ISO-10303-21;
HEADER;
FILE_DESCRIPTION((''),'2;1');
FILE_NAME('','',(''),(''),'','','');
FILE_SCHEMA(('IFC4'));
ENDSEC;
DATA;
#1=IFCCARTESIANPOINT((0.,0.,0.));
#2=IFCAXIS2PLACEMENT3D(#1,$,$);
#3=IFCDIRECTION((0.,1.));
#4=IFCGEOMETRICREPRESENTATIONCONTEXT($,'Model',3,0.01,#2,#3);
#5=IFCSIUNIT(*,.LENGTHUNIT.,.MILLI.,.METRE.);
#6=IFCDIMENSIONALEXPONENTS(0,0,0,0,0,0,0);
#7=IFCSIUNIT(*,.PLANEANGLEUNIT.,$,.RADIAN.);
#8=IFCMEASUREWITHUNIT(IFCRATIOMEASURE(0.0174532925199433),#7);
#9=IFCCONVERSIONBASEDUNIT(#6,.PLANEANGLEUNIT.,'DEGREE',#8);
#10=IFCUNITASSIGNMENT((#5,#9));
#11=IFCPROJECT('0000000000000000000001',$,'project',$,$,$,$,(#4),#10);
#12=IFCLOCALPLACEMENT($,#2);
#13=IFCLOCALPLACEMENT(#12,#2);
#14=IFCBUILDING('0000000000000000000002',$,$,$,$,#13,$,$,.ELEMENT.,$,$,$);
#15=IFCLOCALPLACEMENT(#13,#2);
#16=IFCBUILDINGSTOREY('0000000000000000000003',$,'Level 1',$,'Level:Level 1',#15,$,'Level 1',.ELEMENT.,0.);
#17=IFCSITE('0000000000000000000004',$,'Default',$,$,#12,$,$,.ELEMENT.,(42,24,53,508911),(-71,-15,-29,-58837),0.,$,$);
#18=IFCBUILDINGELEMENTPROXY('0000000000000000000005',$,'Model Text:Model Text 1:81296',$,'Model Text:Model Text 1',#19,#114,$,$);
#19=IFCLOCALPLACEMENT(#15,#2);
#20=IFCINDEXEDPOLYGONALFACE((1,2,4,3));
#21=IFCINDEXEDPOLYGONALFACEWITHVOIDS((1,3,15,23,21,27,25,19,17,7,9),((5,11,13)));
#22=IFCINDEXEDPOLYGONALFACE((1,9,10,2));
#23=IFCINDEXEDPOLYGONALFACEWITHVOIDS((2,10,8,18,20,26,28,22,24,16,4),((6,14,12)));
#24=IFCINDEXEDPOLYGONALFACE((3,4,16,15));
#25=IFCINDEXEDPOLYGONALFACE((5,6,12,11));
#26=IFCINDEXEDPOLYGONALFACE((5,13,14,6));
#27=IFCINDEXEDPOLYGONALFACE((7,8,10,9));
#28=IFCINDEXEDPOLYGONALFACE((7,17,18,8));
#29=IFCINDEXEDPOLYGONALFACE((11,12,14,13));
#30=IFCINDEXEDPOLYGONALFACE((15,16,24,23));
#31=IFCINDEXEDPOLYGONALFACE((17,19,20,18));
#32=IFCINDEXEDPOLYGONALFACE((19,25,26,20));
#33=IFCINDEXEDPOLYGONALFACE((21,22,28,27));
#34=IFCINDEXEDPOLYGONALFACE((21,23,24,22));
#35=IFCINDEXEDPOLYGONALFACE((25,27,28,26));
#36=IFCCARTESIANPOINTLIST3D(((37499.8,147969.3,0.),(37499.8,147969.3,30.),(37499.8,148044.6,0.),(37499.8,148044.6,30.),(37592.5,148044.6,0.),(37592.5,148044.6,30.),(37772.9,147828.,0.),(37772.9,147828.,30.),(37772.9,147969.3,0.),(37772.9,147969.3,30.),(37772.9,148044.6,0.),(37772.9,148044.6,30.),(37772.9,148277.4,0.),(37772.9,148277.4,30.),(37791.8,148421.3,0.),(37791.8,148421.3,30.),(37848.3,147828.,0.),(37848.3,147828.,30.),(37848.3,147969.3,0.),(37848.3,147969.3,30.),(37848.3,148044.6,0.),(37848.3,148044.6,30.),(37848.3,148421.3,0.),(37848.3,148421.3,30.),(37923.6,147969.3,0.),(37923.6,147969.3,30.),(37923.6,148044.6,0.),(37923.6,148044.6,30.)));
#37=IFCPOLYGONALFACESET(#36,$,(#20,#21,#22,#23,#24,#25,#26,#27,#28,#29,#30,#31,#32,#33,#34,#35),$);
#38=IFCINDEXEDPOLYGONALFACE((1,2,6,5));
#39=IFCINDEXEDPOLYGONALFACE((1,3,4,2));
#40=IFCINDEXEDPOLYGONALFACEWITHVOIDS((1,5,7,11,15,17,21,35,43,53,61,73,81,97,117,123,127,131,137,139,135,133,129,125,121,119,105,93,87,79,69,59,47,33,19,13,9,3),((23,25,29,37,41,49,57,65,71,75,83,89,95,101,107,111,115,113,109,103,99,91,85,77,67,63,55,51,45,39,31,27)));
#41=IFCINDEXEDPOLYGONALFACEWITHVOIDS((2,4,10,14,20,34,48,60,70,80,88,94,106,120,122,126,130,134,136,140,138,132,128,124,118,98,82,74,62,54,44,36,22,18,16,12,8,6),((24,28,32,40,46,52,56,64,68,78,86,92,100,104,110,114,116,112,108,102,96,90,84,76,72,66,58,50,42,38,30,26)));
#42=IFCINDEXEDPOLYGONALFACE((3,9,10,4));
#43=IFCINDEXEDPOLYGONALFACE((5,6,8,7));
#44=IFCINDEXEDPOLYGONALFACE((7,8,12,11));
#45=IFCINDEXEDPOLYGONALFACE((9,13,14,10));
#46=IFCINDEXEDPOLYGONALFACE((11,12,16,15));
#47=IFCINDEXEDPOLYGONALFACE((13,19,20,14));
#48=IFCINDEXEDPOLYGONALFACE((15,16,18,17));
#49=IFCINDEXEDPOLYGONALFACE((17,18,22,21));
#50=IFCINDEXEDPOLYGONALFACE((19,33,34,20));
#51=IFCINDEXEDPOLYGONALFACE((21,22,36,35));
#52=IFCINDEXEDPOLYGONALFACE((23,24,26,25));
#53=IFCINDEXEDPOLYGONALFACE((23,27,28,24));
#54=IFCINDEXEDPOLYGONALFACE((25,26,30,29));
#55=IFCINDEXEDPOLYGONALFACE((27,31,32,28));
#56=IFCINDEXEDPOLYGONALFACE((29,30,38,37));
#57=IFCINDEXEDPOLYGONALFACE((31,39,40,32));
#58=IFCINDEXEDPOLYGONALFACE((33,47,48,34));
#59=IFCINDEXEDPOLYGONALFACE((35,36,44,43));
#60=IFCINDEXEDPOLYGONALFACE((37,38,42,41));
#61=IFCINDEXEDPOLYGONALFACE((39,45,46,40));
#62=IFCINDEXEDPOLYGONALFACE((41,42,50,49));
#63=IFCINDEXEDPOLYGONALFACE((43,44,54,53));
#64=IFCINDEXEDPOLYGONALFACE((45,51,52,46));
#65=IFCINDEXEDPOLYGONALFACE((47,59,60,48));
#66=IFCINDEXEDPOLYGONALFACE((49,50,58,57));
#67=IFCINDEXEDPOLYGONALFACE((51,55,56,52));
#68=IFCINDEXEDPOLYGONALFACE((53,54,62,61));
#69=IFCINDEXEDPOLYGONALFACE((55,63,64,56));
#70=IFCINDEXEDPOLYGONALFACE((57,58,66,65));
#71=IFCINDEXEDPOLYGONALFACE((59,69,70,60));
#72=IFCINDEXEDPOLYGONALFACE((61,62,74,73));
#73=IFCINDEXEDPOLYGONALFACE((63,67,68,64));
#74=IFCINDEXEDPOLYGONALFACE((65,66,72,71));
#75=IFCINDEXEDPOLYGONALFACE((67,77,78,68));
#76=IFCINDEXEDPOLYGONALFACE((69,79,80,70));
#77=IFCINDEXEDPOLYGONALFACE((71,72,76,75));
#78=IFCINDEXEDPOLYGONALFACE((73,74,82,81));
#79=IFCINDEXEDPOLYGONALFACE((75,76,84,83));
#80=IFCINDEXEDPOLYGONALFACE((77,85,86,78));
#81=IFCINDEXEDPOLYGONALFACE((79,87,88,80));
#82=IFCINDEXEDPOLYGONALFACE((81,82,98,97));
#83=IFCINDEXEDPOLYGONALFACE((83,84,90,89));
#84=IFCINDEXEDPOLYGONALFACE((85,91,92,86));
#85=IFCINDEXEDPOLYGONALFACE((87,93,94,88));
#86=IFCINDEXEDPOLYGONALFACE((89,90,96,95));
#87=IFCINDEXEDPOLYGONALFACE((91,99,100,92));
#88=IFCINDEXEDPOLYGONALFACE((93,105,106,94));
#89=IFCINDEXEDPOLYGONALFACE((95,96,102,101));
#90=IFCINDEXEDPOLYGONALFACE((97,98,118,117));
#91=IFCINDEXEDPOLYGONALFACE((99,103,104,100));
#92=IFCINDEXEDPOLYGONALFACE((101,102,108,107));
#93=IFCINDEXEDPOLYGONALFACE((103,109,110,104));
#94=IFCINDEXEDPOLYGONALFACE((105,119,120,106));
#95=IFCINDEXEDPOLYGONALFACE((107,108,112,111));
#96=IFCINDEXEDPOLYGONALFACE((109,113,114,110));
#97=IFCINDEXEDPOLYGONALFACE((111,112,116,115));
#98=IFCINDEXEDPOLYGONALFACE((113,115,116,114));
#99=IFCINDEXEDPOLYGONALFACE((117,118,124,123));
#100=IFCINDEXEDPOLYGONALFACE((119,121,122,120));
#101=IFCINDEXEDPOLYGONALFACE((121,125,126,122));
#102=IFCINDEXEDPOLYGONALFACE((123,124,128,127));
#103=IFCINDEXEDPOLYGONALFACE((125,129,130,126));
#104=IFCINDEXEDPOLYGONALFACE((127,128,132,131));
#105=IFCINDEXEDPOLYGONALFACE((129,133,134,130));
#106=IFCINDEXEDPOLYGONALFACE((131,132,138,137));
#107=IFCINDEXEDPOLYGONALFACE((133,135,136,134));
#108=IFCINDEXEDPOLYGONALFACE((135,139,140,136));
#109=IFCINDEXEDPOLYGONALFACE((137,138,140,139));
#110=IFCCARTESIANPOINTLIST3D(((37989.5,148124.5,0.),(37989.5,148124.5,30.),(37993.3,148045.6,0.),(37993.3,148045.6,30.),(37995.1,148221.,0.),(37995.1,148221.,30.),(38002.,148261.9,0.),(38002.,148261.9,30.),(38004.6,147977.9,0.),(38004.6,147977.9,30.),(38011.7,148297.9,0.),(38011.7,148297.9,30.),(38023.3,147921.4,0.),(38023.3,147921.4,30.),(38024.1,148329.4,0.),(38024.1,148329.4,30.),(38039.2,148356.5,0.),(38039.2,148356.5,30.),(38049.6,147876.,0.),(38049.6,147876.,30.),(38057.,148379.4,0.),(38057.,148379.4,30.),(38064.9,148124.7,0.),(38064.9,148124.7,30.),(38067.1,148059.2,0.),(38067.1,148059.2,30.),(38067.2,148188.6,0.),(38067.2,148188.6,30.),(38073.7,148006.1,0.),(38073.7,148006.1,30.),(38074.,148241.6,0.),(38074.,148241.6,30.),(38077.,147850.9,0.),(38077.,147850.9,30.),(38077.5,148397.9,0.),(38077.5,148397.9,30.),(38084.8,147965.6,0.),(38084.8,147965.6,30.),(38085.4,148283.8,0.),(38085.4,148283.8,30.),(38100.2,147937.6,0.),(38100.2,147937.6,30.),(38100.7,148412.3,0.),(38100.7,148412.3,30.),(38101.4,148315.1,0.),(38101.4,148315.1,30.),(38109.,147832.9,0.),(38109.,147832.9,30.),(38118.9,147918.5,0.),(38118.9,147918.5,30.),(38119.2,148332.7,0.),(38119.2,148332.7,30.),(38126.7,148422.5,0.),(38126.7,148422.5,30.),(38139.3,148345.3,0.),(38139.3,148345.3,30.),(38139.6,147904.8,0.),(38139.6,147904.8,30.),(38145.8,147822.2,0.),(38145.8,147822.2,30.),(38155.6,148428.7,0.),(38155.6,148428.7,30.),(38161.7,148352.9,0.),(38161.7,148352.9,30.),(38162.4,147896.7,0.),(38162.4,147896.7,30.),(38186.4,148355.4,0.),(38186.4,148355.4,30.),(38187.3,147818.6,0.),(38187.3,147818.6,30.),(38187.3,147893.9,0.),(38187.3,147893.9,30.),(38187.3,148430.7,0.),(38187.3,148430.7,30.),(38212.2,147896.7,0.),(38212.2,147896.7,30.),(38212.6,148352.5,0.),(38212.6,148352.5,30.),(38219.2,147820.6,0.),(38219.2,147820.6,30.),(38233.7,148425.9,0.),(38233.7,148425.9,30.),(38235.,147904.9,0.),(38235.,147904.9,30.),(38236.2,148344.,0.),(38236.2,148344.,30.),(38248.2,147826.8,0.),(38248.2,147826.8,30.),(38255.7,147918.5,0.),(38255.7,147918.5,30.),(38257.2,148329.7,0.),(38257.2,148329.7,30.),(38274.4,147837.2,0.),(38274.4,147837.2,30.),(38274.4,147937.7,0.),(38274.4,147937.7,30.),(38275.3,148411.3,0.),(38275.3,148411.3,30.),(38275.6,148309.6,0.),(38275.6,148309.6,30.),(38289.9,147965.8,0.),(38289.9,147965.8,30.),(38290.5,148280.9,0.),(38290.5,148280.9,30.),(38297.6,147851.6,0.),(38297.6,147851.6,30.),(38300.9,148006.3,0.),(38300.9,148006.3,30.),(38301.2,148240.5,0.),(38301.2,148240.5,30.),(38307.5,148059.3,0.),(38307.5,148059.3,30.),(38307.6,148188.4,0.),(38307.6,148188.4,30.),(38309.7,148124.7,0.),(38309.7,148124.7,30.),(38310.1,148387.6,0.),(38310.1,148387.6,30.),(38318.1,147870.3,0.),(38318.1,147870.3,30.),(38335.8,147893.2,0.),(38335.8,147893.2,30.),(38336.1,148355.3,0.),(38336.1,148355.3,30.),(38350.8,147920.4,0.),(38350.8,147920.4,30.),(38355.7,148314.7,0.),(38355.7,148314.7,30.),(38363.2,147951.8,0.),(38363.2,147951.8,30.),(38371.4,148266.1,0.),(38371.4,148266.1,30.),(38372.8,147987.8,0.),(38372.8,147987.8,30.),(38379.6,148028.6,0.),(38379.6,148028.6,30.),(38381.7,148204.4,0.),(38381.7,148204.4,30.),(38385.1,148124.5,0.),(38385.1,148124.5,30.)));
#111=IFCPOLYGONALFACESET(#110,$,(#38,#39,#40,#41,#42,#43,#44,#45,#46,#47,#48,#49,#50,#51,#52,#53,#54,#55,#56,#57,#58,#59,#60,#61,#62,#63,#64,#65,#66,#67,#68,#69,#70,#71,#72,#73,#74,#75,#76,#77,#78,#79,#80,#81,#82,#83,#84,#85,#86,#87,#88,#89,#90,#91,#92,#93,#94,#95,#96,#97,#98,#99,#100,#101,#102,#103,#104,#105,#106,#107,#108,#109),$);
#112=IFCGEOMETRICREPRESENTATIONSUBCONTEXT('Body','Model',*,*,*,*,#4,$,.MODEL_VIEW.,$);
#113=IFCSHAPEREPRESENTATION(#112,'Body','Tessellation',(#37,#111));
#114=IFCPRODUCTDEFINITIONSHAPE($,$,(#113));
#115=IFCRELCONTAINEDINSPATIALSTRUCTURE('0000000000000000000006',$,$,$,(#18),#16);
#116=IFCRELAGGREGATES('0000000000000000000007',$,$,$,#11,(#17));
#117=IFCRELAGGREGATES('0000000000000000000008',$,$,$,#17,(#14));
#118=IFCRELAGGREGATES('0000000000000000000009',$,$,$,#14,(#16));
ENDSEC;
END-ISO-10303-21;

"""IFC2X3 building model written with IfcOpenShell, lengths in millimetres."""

from ifc_helpers import new_model, entity, si_unit, converted_unit, direction, frame, origin, place, context, subcontext, project, spatial, polyline, outline, extrude, element, save


model = new_model("IFC2X3")

# Units and contexts
model_context = context("Model", 3, precision=0.01, world=origin(), true_north=direction((0.0, 1.0)))
body_context = subcontext(model_context, "Body", "Model", "MODEL_VIEW")
ifc_project = project(units=[si_unit("LENGTHUNIT", "METRE", prefix="MILLI"), converted_unit("PLANEANGLEUNIT", "DEGREE", entity("IfcRatioMeasure", 0.0174532925199433), si_unit("PLANEANGLEUNIT", "RADIAN"), dimensions=[0, 0, 0, 0, 0, 0, 0])], contexts=[model_context])

# Site, building, storey
site_placement = place(None, origin())
site = spatial("IfcSite", under=ifc_project, at=site_placement, Name="Default", CompositionType="ELEMENT", RefLatitude=(42, 24, 53, 508911), RefLongitude=(-71, -15, -29, -58837), RefElevation=0.0)
building_placement = place(site_placement, origin())
building = spatial("IfcBuilding", under=site, at=building_placement, CompositionType="ELEMENT")
storey_placement = place(building_placement, origin())
storey = spatial("IfcBuildingStorey", under=building, at=storey_placement, Name="Level 1", ObjectType="Level:Level 1", LongName="Level 1", CompositionType="ELEMENT", Elevation=0.0)

# Building element proxy
proxy_1_placement = place(storey_placement, origin())
element("IfcBuildingElementProxy", 1, at=proxy_1_placement, inside=storey, Name="Model Text:Model Text 1:81296", ObjectType="Model Text:Model Text 1", context=body_context, shape_type="SweptSolid", body=[
    extrude(outline(polyline([(-6.8, -218.3), (68.5, -218.3), (68.5, -77.1), (143.8, -77.1), (143.8, -1.7), (68.5, -1.7), (68.5, 375.0), (12.0, 375.0), (-280.0, -1.7), (-280.0, -77.1), (-6.8, -77.1), (-6.8, -218.3)]), holes=[polyline([(-6.8, -1.7), (-187.3, -1.7), (-6.8, 231.1), (-6.8, -1.7)])]), frame((37779.8, 148046.3, 0.0)), (0.0, 0.0, 1.0), 30.0),
    extrude(outline(polyline([(-10.6, -198.7), (68.3, -198.7), (136.5, -190.7), (193.9, -174.7), (240.5, -150.6), (266.9, -124.4), (286.3, -93.2), (298.8, -57.0), (304.3, -15.7), (303.8, 16.2), (299.0, 45.5), (289.9, 72.1), (276.6, 96.0), (258.9, 117.3), (236.9, 136.2), (210.4, 152.5), (179.6, 166.3), (144.1, 177.6), (103.7, 186.3), (8.2, 196.4), (-71.8, 196.7), (-134.0, 189.4), (-183.3, 176.1), (-224.7, 158.4), (-258.2, 133.9), (-283.5, 100.3), (-300.1, 59.5), (-307.1, 13.4), (-306.6, -18.4), (-301.8, -47.5), (-292.8, -74.0), (-279.6, -97.9), (-262.0, -119.2), (-240.0, -138.1), (-213.6, -154.5), (-182.8, -168.4), (-147.3, -179.8), (-106.7, -188.6), (-10.6, -198.7)]), holes=[polyline([(-7.2, -123.5), (-71.0, -118.2), (-123.6, -108.8), (-165.2, -95.4), (-195.7, -78.0), (-212.4, -59.4), (-224.1, -38.7), (-230.6, -15.9), (-231.9, 8.9), (-227.8, 35.0), (-218.1, 58.1), (-202.8, 78.4), (-182.0, 95.8), (-152.6, 109.4), (-111.7, 118.1), (-59.4, 122.0), (4.4, 121.1), (69.6, 115.8), (122.2, 106.7), (162.2, 93.7), (189.5, 77.0), (207.7, 57.4), (220.4, 36.0), (227.5, 12.8), (229.1, -12.1), (225.2, -36.8), (215.9, -59.2), (201.3, -79.3), (181.4, -97.1), (152.6, -111.2), (111.6, -120.3), (58.3, -124.4), (-7.2, -123.5)])]), frame((38188.6, 148123.3, 0.0), z_axis=(0.0, 0.0, 1.0), x_axis=(0.047515, -0.998871, 0.0)), (0.0, 0.0, 1.0), 30.0),
])

save(model, "model.ifc")
